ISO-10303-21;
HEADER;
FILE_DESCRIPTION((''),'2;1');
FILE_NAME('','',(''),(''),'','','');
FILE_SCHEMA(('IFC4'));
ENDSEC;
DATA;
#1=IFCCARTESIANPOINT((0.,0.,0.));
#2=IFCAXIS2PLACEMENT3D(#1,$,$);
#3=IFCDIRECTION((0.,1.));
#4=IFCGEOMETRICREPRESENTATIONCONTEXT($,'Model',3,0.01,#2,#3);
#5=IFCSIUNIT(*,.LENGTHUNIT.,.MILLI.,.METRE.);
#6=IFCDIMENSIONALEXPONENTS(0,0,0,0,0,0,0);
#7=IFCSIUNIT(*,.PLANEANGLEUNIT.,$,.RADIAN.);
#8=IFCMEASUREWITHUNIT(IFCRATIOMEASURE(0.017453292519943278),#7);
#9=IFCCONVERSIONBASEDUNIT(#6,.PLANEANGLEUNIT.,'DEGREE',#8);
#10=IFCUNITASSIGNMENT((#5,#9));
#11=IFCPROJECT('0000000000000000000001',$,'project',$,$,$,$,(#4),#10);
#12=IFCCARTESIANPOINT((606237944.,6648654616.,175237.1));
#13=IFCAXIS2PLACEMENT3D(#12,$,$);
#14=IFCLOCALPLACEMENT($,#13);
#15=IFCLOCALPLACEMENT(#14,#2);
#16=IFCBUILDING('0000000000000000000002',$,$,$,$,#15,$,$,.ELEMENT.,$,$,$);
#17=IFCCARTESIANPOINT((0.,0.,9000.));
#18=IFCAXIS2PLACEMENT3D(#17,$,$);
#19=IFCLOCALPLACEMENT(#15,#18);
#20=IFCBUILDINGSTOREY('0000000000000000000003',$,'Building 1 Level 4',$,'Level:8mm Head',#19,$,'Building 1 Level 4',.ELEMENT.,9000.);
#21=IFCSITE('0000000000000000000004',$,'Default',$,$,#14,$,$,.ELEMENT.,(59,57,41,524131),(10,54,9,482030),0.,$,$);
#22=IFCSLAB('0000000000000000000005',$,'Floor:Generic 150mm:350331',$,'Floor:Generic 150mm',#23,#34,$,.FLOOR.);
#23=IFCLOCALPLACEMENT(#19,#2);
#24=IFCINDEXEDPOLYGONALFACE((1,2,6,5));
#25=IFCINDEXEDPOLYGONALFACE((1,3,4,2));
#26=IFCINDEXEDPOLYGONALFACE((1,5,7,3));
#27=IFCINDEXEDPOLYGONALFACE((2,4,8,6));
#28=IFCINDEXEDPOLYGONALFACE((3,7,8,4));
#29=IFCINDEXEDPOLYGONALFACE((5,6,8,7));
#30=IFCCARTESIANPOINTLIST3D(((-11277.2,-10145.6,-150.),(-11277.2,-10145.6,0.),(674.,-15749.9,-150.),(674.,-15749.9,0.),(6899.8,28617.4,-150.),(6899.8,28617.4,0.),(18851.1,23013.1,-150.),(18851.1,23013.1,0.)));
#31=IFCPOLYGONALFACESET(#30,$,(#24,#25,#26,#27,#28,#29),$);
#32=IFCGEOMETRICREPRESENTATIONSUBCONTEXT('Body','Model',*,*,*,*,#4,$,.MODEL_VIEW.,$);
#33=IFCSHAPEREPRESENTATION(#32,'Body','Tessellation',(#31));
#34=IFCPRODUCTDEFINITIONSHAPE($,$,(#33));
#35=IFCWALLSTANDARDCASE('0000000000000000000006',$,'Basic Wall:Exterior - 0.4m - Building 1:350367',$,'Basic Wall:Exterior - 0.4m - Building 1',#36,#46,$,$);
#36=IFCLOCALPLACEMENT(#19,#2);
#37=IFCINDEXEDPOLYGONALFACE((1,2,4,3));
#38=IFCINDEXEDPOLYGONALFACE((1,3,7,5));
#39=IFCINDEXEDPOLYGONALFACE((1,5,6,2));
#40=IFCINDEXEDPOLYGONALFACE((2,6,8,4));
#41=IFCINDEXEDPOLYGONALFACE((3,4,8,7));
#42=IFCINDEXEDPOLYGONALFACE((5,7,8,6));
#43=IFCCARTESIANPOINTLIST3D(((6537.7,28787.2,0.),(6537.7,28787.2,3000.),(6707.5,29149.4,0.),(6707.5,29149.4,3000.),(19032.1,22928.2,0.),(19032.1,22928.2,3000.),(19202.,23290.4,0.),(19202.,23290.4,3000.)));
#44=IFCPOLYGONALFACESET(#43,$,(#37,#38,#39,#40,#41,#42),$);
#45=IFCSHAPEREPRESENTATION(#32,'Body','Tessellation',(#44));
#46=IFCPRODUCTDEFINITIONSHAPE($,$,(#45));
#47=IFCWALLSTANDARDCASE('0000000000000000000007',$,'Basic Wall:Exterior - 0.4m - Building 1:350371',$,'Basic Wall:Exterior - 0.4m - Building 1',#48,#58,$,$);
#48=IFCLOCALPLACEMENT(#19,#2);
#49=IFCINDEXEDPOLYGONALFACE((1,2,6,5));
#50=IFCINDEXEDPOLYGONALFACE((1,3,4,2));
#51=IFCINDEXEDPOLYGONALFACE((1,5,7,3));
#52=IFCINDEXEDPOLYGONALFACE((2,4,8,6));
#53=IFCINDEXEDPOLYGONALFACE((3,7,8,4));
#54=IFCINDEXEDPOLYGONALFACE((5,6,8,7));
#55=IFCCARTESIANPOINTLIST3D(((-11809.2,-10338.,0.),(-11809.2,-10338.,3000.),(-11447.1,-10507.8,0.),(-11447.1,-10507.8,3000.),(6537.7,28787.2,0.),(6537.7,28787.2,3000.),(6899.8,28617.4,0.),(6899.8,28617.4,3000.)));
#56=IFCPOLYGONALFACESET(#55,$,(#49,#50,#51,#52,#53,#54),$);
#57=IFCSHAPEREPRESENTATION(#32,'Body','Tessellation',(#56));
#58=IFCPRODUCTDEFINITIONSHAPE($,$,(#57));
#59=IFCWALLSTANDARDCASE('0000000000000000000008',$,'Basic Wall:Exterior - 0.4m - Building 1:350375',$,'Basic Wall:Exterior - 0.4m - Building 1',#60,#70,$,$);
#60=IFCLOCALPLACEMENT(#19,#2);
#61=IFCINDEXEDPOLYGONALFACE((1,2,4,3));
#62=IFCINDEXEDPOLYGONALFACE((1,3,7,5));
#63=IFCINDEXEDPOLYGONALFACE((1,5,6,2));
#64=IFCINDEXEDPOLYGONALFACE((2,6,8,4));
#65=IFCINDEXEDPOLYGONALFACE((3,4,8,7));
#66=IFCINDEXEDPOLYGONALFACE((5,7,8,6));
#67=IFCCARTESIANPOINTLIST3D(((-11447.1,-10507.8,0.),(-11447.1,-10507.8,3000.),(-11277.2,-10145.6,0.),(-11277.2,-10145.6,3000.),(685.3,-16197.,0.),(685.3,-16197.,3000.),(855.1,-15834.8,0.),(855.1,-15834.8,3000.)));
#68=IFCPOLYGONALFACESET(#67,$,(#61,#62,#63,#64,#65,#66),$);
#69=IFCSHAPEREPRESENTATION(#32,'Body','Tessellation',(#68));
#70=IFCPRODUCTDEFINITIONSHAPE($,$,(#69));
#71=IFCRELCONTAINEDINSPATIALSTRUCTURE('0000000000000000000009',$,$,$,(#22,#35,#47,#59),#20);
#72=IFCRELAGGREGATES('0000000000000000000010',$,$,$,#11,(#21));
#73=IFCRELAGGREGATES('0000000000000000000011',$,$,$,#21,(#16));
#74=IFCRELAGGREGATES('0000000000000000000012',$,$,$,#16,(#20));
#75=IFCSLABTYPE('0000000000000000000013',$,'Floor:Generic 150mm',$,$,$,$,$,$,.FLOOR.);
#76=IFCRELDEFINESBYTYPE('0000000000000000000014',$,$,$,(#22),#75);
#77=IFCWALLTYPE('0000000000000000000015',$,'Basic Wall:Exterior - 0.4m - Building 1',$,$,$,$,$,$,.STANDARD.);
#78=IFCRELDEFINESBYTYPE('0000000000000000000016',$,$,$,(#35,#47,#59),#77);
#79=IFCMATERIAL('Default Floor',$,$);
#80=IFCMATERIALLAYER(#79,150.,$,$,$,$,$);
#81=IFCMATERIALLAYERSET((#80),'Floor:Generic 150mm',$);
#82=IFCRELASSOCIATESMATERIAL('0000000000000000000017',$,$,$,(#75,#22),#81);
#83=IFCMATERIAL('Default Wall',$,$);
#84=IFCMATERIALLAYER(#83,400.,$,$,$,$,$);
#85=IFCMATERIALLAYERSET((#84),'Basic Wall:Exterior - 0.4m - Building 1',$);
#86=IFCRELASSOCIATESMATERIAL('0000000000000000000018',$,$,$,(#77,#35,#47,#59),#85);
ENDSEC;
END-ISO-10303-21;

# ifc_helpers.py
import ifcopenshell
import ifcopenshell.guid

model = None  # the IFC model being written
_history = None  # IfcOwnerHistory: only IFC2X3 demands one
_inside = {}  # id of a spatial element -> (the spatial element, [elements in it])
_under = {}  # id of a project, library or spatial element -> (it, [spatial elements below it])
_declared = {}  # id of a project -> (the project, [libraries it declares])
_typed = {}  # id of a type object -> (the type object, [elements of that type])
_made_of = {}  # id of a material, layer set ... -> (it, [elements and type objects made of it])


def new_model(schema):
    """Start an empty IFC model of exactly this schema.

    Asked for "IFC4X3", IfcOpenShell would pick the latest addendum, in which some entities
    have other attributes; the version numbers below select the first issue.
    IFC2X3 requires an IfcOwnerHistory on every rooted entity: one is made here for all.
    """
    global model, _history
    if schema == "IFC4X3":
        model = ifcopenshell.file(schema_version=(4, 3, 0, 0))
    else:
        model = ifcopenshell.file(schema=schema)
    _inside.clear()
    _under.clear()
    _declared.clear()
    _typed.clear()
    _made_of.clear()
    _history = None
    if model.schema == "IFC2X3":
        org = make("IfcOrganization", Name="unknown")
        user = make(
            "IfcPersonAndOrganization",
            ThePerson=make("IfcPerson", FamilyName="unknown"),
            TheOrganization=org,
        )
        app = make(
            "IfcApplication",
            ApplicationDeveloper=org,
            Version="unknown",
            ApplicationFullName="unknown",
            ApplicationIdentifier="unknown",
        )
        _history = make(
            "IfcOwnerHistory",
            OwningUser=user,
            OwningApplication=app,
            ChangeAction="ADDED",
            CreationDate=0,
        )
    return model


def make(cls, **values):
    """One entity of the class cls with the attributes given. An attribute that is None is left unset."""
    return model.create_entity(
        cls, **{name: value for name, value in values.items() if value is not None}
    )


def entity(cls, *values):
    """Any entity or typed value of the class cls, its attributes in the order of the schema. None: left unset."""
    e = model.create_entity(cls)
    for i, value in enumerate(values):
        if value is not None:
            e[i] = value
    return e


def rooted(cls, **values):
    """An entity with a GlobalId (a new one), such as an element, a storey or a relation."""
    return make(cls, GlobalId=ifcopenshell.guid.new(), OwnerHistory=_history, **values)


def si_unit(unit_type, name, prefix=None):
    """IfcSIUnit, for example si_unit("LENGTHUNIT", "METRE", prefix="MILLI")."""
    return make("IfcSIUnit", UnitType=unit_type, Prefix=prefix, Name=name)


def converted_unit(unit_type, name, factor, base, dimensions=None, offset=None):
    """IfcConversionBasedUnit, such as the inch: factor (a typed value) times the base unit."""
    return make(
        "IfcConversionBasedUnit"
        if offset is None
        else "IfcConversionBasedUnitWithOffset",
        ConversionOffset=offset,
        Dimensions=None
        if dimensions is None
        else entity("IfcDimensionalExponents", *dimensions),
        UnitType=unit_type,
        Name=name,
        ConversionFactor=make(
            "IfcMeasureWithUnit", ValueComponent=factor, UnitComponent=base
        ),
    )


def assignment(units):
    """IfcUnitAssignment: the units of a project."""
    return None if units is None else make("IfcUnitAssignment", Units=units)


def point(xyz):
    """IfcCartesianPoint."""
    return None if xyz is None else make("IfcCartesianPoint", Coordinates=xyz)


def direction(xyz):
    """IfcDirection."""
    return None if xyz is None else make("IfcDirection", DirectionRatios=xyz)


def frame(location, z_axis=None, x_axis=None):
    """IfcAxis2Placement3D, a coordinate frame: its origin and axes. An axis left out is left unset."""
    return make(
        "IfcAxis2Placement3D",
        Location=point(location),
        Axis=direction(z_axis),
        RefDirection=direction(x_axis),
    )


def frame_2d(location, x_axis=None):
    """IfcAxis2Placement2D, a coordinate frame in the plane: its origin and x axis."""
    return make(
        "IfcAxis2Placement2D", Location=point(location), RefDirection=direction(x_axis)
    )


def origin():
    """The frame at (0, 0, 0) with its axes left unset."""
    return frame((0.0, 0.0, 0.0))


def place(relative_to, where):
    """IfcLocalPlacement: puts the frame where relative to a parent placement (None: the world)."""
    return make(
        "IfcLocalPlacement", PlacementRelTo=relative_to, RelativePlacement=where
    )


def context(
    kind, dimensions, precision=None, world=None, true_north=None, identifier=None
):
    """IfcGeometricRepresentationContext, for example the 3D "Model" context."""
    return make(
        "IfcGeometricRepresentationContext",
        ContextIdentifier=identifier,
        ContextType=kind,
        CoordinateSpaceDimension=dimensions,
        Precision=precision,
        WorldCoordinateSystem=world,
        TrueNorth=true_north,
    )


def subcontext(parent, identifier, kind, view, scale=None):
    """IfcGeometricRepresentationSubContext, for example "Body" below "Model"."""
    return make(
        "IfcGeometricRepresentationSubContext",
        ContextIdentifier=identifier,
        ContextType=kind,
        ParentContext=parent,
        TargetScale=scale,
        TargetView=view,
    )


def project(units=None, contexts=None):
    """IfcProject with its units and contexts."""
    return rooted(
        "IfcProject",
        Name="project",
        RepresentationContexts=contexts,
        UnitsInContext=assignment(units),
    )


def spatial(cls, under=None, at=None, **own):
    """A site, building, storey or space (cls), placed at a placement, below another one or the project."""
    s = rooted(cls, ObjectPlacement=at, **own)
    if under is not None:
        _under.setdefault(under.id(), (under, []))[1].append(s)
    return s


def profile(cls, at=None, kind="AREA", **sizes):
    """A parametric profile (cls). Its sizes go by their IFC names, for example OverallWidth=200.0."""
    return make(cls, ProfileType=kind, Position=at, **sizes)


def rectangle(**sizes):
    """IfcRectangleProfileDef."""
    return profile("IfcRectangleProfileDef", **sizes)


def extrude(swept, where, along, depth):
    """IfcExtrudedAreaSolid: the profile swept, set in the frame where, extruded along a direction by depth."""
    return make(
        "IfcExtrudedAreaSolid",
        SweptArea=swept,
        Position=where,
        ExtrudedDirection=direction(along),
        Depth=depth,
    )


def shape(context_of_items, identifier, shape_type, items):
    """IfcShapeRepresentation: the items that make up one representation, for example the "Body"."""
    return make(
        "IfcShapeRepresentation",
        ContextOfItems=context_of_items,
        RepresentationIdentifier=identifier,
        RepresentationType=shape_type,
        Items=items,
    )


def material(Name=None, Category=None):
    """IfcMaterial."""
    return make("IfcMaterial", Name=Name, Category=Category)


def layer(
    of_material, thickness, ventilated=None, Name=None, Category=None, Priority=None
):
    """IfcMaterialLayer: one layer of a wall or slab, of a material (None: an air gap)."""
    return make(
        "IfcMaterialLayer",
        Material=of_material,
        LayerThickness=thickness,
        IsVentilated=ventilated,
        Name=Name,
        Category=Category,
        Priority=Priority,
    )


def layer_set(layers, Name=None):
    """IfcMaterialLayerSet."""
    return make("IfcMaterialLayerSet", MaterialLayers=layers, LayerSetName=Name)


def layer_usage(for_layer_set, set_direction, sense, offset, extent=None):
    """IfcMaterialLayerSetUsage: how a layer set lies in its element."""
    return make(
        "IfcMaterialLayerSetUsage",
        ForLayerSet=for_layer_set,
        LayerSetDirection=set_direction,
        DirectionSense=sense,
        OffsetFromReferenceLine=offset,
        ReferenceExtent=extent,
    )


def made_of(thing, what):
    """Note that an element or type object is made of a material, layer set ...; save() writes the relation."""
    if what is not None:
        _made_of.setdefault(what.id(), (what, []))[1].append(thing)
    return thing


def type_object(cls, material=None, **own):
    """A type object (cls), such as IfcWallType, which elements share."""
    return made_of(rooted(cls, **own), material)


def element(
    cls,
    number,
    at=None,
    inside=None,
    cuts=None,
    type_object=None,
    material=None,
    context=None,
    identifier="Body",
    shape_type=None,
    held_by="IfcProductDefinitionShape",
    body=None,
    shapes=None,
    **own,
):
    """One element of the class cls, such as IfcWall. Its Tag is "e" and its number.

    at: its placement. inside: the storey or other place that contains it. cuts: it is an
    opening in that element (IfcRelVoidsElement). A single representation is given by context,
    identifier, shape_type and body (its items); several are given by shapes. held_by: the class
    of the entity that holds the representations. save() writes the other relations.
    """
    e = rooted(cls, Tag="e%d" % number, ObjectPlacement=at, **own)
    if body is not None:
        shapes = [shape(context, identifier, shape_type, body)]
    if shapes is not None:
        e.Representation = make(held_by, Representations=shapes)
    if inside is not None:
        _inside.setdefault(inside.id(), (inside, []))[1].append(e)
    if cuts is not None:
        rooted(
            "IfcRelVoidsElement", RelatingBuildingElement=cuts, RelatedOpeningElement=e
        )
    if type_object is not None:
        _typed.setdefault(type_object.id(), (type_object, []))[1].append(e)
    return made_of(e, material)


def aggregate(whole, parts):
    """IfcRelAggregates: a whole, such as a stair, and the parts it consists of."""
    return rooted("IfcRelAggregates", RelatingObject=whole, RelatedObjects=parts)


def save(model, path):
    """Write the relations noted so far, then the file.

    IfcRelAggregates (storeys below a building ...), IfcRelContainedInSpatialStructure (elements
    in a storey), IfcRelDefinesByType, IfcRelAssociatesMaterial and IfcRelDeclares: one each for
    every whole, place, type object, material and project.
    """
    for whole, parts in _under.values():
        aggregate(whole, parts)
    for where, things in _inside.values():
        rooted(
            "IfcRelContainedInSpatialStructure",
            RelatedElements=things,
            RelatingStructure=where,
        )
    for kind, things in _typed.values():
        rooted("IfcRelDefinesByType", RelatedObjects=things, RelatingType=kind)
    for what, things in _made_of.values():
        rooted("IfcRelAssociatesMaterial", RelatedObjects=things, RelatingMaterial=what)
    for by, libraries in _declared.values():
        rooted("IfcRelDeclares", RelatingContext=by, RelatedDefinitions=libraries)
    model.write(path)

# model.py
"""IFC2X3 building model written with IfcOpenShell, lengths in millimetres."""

from ifc_helpers import new_model, entity, si_unit, converted_unit, direction, frame, frame_2d, origin, place, context, subcontext, project, spatial, rectangle, extrude, material, layer, layer_set, layer_usage, type_object, element, save


model = new_model("IFC2X3")

# Units and contexts
model_context = context("Model", 3, precision=0.01, world=origin(), true_north=direction((0.0, 1.0)))
body_context = subcontext(model_context, "Body", "Model", "MODEL_VIEW")
ifc_project = project(units=[si_unit("LENGTHUNIT", "METRE", prefix="MILLI"), converted_unit("PLANEANGLEUNIT", "DEGREE", entity("IfcRatioMeasure", 0.017453292519943278), si_unit("PLANEANGLEUNIT", "RADIAN"), dimensions=[0, 0, 0, 0, 0, 0, 0])], contexts=[model_context])

# Site, building, storey
site_placement = place(None, frame((606237944.0, 6648654616.0, 175237.1)))
site = spatial("IfcSite", under=ifc_project, at=site_placement, Name="Default", CompositionType="ELEMENT", RefLatitude=(59, 57, 41, 524131), RefLongitude=(10, 54, 9, 482030), RefElevation=0.0)
building_placement = place(site_placement, origin())
building = spatial("IfcBuilding", under=site, at=building_placement, CompositionType="ELEMENT")
storey_placement = place(building_placement, frame((0.0, 0.0, 9000.0)))
storey = spatial("IfcBuildingStorey", under=building, at=storey_placement, Name="Building 1 Level 4", ObjectType="Level:8mm Head", LongName="Building 1 Level 4", CompositionType="ELEMENT", Elevation=9000.0)

# Slab
ifc_material_1 = material(Name="Default Floor")
ifc_layer_1 = layer(ifc_material_1, 150.0)
ifc_layer_set_1 = layer_set([ifc_layer_1], Name="Floor:Generic 150mm")
ifc_layer_usage_1 = layer_usage(ifc_layer_set_1, "AXIS3", "POSITIVE", 0.0)
slab_type = type_object("IfcSlabType", Name="Floor:Generic 150mm", PredefinedType="FLOOR", material=ifc_layer_set_1)
slab_placement = place(storey_placement, origin())
element("IfcSlab", 1, at=slab_placement, inside=storey, type_object=slab_type, material=ifc_layer_usage_1, Name="Floor:Generic 150mm:350331", ObjectType="Floor:Generic 150mm", PredefinedType="FLOOR", context=body_context, shape_type="SweptSolid", body=[
    extrude(rectangle(XDim=13200.0, YDim=42813.3, at=frame_2d((0.0, 0.0), x_axis=(1.0, 0.0))), frame((3786.9, 6433.8, 0.0), z_axis=(0.0, 0.0, -1.0), x_axis=(0.905397, -0.424566, 0.0)), (0.0, 0.0, 1.0), 150.0),
])

# Walls
ifc_material_2 = material(Name="Default Wall")
ifc_layer_2 = layer(ifc_material_2, 400.0)
ifc_layer_set_2 = layer_set([ifc_layer_2], Name="Basic Wall:Exterior - 0.4m - Building 1")
ifc_layer_usage_2 = layer_usage(ifc_layer_set_2, "AXIS2", "POSITIVE", -200.0)
wall_type = type_object("IfcWallType", Name="Basic Wall:Exterior - 0.4m - Building 1", PredefinedType="STANDARD", material=ifc_layer_set_2)
wall_1_placement = place(storey_placement, frame((19117.1, 23109.3, 0.0), z_axis=(0.0, 0.0, 1.0), x_axis=(-0.905397, 0.424566, 0.0)))
element("IfcWallStandardCase", 2, at=wall_1_placement, inside=storey, type_object=wall_type, material=ifc_layer_usage_2, Name="Basic Wall:Exterior - 0.4m - Building 1:350367", ObjectType="Basic Wall:Exterior - 0.4m - Building 1", context=body_context, shape_type="SweptSolid", body=[
    extrude(rectangle(XDim=13800.0, YDim=400.0, at=frame_2d((6900.0, 0.0), x_axis=(-1.0, 0.0))), origin(), (0.0, 0.0, 1.0), 3000.0),
])
wall_2_placement = place(storey_placement, frame((6718.7, 28702.3, 0.0), z_axis=(0.0, 0.0, 1.0), x_axis=(-0.424566, -0.905397, 0.0)))
element("IfcWallStandardCase", 3, at=wall_2_placement, inside=storey, type_object=wall_type, material=ifc_layer_usage_2, Name="Basic Wall:Exterior - 0.4m - Building 1:350371", ObjectType="Basic Wall:Exterior - 0.4m - Building 1", context=body_context, shape_type="SweptSolid", body=[
    extrude(rectangle(XDim=43213.3, YDim=400.0, at=frame_2d((21606.7, 0.0), x_axis=(-1.0, 0.0))), origin(), (0.0, 0.0, 1.0), 3000.0),
])
wall_3_placement = place(storey_placement, frame((-11362.2, -10326.7, 0.0), z_axis=(0.0, 0.0, 1.0), x_axis=(0.905397, -0.424566, 0.0)))
element("IfcWallStandardCase", 4, at=wall_3_placement, inside=storey, type_object=wall_type, material=ifc_layer_usage_2, Name="Basic Wall:Exterior - 0.4m - Building 1:350375", ObjectType="Basic Wall:Exterior - 0.4m - Building 1", context=body_context, shape_type="SweptSolid", body=[
    extrude(rectangle(XDim=13400.0, YDim=400.0, at=frame_2d((6700.0, 0.0), x_axis=(-1.0, 0.0))), origin(), (0.0, 0.0, 1.0), 3000.0),
])

save(model, "model.ifc")
